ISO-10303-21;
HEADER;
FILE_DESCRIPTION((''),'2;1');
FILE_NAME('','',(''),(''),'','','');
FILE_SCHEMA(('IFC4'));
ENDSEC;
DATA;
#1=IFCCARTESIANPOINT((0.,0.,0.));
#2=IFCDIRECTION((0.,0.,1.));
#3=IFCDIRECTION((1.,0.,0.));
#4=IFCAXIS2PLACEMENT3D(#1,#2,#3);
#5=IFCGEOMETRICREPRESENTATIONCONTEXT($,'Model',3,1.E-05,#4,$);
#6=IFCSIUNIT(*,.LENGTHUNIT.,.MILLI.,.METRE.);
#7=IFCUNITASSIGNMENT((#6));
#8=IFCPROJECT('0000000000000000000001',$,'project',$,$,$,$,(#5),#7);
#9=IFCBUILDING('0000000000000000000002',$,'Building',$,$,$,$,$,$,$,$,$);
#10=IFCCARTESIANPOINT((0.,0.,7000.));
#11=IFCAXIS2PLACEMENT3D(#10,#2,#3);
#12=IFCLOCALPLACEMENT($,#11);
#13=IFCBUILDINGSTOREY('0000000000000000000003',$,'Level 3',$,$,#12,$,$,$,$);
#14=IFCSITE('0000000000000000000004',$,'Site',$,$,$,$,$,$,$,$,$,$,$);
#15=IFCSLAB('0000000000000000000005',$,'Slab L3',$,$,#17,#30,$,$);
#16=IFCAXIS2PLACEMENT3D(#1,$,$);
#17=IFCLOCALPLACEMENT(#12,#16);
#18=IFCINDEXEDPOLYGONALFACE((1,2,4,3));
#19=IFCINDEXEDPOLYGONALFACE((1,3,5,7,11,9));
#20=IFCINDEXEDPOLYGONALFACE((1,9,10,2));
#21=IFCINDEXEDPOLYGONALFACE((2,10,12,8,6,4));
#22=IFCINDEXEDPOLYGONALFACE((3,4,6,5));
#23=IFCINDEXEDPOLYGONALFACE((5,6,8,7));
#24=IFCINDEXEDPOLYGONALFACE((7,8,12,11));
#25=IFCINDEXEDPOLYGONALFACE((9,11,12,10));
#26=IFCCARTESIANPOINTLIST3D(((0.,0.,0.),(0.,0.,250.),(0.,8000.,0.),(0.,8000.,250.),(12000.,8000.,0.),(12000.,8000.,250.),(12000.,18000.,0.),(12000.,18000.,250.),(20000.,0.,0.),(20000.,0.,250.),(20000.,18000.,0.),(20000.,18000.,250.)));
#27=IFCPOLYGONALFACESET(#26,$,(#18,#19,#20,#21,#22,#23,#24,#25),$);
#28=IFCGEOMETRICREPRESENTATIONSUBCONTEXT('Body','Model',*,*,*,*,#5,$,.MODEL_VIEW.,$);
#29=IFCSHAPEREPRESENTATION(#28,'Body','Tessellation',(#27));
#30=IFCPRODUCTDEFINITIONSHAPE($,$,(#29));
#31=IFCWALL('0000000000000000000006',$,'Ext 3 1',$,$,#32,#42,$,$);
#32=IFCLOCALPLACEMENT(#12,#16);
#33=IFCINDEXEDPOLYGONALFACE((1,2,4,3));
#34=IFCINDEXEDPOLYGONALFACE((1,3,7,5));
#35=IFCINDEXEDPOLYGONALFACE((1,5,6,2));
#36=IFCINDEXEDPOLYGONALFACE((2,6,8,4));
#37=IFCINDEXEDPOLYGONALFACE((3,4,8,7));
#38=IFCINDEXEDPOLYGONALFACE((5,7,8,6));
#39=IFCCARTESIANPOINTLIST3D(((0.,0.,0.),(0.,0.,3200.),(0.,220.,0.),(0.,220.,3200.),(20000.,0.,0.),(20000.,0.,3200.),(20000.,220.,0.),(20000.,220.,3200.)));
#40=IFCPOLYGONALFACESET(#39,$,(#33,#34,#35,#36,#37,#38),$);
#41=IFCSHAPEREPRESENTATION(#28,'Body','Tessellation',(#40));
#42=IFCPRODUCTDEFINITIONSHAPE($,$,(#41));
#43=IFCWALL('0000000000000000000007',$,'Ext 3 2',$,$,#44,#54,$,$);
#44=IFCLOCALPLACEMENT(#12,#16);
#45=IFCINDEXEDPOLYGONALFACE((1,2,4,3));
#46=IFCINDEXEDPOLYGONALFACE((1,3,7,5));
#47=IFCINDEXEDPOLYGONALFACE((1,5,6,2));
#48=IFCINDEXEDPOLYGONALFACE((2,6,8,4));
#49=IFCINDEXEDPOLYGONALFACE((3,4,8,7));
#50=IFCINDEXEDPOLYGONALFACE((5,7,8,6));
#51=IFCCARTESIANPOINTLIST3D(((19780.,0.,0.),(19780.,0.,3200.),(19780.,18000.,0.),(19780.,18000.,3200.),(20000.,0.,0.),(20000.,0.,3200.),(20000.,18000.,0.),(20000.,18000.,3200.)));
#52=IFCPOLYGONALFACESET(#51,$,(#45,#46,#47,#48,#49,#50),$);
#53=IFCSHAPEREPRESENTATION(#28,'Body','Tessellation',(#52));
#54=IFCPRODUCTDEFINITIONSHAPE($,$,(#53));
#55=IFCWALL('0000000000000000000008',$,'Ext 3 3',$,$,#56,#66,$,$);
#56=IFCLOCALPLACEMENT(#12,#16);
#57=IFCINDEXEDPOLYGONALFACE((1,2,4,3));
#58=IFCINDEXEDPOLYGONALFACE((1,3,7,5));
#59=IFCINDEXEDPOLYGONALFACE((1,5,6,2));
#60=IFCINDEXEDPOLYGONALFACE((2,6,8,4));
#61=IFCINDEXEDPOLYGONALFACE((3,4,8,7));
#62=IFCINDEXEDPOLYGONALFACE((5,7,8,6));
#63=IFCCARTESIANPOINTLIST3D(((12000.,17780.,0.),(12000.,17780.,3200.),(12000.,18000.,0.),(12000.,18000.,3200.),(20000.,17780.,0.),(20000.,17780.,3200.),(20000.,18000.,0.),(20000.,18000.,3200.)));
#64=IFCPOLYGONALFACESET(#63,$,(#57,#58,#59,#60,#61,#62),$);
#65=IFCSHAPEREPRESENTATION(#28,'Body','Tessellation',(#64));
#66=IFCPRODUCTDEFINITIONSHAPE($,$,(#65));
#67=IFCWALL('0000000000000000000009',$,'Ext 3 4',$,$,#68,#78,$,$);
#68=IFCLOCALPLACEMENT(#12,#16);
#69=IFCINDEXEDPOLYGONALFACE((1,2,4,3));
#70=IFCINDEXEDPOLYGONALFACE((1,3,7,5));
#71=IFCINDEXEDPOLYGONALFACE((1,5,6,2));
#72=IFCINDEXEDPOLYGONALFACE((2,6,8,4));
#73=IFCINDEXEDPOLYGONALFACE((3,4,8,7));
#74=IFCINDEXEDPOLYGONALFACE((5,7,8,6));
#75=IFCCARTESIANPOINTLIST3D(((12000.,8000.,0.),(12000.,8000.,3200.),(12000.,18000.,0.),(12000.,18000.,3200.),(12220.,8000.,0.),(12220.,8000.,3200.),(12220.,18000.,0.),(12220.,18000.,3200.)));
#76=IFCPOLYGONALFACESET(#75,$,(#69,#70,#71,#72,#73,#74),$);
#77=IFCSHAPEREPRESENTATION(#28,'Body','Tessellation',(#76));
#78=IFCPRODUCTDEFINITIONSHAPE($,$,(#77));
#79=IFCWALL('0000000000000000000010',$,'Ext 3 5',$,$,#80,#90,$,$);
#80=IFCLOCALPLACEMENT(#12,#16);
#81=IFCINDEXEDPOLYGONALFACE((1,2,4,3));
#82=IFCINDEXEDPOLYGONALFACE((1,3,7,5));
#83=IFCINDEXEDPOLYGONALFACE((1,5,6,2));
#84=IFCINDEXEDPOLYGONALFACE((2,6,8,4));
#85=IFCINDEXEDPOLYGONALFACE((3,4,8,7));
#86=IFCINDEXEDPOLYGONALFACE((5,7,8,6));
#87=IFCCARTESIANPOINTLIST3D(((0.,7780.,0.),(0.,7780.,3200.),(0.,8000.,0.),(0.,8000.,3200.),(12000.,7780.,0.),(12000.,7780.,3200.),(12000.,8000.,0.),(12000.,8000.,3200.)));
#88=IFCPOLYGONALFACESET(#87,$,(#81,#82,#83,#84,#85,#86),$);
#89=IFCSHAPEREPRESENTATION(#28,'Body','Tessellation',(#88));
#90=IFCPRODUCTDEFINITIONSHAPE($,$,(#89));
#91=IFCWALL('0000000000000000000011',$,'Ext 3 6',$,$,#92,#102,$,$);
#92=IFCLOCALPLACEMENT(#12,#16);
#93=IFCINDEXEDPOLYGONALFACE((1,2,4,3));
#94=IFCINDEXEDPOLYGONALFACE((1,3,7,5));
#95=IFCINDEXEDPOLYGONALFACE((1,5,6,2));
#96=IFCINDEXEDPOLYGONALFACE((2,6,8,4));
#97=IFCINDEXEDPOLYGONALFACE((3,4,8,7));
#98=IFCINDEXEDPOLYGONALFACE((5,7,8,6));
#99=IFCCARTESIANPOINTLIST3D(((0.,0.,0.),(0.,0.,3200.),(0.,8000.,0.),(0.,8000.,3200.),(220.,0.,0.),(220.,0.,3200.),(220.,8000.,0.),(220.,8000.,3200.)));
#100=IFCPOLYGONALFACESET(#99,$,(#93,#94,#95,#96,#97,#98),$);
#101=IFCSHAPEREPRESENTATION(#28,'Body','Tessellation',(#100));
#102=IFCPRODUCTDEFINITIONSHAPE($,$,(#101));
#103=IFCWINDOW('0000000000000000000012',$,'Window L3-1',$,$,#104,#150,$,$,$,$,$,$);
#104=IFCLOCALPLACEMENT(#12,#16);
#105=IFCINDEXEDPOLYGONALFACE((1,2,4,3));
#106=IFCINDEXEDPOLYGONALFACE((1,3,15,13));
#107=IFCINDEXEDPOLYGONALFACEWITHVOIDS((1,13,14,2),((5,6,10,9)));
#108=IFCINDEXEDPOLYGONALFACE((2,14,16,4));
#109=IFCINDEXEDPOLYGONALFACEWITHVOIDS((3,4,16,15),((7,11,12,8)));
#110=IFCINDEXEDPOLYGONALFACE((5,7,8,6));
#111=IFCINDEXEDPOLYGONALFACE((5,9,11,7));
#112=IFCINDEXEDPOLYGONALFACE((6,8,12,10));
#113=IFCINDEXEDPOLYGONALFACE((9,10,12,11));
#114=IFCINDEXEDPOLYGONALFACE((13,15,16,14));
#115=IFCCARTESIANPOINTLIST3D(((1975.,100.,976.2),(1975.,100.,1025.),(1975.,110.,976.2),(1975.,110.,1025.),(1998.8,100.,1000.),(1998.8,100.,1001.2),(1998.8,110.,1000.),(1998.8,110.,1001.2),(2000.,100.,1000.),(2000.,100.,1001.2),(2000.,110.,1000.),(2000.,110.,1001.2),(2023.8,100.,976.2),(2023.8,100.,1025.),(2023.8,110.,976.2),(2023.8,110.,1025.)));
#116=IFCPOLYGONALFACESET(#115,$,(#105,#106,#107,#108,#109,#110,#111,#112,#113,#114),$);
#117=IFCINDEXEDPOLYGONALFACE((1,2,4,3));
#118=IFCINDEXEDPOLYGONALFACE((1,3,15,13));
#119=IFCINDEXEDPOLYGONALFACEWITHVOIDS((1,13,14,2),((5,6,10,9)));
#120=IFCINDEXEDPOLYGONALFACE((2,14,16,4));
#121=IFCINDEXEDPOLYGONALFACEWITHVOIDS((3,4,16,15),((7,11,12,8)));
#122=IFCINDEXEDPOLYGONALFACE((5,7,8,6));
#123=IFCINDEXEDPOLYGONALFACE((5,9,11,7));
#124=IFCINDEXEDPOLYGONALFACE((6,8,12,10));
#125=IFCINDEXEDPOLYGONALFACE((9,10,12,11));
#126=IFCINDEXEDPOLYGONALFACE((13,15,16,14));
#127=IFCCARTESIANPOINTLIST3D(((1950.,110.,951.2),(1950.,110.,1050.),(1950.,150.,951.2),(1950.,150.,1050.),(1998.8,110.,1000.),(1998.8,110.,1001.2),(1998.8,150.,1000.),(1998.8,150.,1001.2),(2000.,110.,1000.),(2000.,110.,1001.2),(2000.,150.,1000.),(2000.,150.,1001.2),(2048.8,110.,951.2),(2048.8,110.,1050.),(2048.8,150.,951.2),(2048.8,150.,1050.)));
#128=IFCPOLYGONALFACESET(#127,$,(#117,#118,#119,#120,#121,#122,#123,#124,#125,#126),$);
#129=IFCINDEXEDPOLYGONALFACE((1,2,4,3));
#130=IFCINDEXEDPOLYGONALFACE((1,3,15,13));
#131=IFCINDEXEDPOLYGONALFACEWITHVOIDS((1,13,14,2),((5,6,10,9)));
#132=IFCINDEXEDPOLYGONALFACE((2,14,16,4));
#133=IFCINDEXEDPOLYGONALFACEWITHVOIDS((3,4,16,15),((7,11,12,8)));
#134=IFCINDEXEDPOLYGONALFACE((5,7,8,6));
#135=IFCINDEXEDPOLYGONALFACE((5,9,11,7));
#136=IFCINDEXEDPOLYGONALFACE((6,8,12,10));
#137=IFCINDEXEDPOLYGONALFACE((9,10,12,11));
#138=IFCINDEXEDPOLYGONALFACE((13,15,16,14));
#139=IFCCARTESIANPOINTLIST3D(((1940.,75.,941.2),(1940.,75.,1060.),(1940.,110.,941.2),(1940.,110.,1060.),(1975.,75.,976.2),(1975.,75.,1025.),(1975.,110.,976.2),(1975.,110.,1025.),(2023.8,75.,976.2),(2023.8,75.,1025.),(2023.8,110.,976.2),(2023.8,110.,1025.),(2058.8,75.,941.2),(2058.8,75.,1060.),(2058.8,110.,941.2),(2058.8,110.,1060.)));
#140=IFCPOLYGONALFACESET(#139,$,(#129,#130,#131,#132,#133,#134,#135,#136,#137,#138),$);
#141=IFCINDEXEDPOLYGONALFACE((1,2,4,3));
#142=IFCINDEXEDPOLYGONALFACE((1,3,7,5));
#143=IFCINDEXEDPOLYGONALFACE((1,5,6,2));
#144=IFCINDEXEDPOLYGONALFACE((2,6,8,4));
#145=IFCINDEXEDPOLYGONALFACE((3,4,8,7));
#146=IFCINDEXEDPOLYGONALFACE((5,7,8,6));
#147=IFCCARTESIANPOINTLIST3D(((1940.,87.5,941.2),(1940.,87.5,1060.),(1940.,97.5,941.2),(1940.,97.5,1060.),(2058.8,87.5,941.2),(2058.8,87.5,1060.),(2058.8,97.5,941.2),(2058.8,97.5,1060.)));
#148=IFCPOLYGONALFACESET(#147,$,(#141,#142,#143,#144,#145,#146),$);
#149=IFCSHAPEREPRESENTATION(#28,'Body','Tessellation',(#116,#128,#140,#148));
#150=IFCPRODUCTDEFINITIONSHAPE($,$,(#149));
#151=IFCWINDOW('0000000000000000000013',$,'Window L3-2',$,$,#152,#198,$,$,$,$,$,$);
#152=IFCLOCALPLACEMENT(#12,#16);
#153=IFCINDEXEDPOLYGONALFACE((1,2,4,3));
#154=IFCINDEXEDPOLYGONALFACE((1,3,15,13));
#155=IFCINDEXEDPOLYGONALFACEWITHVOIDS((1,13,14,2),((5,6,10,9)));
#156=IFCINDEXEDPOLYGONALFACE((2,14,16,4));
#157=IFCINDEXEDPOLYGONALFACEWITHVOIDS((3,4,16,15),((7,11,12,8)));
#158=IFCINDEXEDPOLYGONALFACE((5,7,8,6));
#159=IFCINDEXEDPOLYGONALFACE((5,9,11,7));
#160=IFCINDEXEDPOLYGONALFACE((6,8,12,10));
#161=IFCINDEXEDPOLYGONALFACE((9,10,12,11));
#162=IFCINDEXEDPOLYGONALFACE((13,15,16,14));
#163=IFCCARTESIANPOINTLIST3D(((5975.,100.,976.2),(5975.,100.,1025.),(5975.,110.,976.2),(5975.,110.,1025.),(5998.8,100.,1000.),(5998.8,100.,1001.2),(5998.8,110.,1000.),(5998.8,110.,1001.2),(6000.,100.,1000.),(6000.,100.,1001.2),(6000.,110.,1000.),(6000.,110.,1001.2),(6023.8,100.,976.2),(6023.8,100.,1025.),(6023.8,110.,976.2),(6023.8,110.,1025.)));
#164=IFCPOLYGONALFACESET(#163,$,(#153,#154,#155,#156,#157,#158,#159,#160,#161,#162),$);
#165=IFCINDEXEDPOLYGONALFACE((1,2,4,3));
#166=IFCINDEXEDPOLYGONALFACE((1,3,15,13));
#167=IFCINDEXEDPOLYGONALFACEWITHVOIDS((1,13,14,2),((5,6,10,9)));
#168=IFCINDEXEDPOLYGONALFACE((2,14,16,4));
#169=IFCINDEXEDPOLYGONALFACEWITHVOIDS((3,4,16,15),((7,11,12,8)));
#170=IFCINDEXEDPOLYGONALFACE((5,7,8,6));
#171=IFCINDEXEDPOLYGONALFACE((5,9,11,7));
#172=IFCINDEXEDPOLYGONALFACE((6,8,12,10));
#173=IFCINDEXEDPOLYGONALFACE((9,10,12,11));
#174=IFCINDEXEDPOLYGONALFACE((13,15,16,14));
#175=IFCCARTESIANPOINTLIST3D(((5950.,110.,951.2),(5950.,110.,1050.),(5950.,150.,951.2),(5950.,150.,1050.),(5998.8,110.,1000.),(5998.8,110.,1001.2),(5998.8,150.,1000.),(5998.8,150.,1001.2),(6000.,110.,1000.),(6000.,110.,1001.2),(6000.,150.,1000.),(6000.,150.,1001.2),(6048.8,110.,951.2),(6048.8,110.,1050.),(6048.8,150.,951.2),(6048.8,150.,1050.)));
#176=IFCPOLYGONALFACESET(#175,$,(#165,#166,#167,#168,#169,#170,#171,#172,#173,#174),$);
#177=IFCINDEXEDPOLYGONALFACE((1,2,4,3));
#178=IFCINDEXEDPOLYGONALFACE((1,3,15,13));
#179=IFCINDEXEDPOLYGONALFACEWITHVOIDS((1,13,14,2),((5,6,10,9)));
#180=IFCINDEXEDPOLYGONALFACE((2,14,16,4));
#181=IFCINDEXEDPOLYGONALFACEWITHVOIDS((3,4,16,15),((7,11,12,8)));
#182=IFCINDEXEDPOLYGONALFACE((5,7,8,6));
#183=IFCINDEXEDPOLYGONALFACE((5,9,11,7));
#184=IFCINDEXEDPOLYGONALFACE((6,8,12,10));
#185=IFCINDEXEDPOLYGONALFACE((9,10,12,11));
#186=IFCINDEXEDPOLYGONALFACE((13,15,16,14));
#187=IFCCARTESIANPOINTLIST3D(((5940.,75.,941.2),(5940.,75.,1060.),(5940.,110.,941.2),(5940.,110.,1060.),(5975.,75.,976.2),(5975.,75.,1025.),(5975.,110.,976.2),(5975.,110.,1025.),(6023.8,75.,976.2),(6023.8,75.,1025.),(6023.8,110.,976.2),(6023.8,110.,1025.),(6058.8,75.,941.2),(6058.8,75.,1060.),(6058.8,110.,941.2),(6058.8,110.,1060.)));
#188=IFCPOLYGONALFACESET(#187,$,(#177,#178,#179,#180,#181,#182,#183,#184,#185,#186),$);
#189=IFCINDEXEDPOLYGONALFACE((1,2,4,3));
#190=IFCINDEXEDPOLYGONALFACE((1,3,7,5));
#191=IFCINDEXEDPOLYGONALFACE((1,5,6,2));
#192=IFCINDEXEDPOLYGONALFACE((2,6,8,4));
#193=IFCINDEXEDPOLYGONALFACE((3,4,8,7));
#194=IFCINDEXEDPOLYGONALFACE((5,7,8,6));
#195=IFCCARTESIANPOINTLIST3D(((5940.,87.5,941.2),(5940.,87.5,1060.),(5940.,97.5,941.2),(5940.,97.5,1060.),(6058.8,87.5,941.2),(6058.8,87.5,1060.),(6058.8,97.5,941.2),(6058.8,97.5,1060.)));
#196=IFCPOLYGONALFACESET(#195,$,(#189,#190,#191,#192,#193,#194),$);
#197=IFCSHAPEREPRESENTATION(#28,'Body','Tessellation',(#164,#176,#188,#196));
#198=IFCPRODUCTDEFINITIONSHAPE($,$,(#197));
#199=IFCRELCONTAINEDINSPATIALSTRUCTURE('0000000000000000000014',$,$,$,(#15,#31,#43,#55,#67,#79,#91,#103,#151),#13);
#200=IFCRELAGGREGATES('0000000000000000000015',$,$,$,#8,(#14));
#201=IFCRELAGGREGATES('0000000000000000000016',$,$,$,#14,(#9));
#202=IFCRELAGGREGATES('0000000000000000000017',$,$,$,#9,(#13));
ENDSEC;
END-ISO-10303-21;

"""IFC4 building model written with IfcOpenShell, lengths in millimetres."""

from ifc_helpers import new_model, si_unit, frame, origin_with_axes, place, context, subcontext, project, spatial, line, indexed_curve, outline, extrude, element, save


model = new_model("IFC4")

# Units and contexts
model_context = context("Model", 3, precision=1e-05, world=origin_with_axes())
body_context = subcontext(model_context, "Body", "Model", "MODEL_VIEW")
ifc_project = project(units=[si_unit("LENGTHUNIT", "METRE", prefix="MILLI")], contexts=[model_context])

# Site, building, storey
site = spatial("IfcSite", under=ifc_project, Name="Site")
building = spatial("IfcBuilding", under=site, Name="Building")
storey_placement = place(None, frame((0.0, 0.0, 7000.0), z_axis=(0.0, 0.0, 1.0), x_axis=(1.0, 0.0, 0.0)))
storey = spatial("IfcBuildingStorey", under=building, at=storey_placement, Name="Level 3")

# Slab
slab_placement = place(storey_placement, origin_with_axes())
element("IfcSlab", 1, at=slab_placement, inside=storey, Name="Slab L3", context=body_context, shape_type="SweptSolid", body=[
    extrude(outline(indexed_curve([(0.0, 0.0), (20000.0, 0.0), (20000.0, 18000.0), (12000.0, 18000.0), (12000.0, 8000.0), (0.0, 8000.0), (0.0, 0.0)])), None, (0.0, 0.0, 1.0), 250.0),
])

# Walls
wall_1_placement = place(storey_placement, origin_with_axes())
element("IfcWall", 2, at=wall_1_placement, inside=storey, Name="Ext 3 1", context=body_context, shape_type="SweptSolid", body=[
    extrude(outline(indexed_curve([(0.0, 0.0), (0.0, 220.0), (20000.0, 220.0), (20000.0, 0.0), (0.0, 0.0)], self_intersect=False)), origin_with_axes(), (0.0, 0.0, 1.0), 3200.0),
])
wall_2_placement = place(storey_placement, frame((20000.0, 0.0, 0.0), z_axis=(0.0, 0.0, 1.0), x_axis=(0.0, 1.0, 0.0)))
element("IfcWall", 3, at=wall_2_placement, inside=storey, Name="Ext 3 2", context=body_context, shape_type="SweptSolid", body=[
    extrude(outline(indexed_curve([(0.0, 0.0), (0.0, 220.0), (18000.0, 220.0), (18000.0, 0.0), (0.0, 0.0)], self_intersect=False)), origin_with_axes(), (0.0, 0.0, 1.0), 3200.0),
])
wall_3_placement = place(storey_placement, frame((20000.0, 18000.0, 0.0), z_axis=(0.0, 0.0, 1.0), x_axis=(-1.0, 0.0, 0.0)))
element("IfcWall", 4, at=wall_3_placement, inside=storey, Name="Ext 3 3", context=body_context, shape_type="SweptSolid", body=[
    extrude(outline(indexed_curve([(0.0, 0.0), (0.0, 220.0), (8000.0, 220.0), (8000.0, 0.0), (0.0, 0.0)], self_intersect=False)), origin_with_axes(), (0.0, 0.0, 1.0), 3200.0),
])
wall_4_placement = place(storey_placement, frame((12000.0, 18000.0, 0.0), z_axis=(0.0, 0.0, 1.0), x_axis=(0.0, -1.0, 0.0)))
element("IfcWall", 5, at=wall_4_placement, inside=storey, Name="Ext 3 4", context=body_context, shape_type="SweptSolid", body=[
    extrude(outline(indexed_curve([(0.0, 0.0), (0.0, 220.0), (10000.0, 220.0), (10000.0, 0.0), (0.0, 0.0)], self_intersect=False)), origin_with_axes(), (0.0, 0.0, 1.0), 3200.0),
])
wall_5_placement = place(storey_placement, frame((12000.0, 8000.0, 0.0), z_axis=(0.0, 0.0, 1.0), x_axis=(-1.0, 0.0, 0.0)))
element("IfcWall", 6, at=wall_5_placement, inside=storey, Name="Ext 3 5", context=body_context, shape_type="SweptSolid", body=[
    extrude(outline(indexed_curve([(0.0, 0.0), (0.0, 220.0), (12000.0, 220.0), (12000.0, 0.0), (0.0, 0.0)], self_intersect=False)), origin_with_axes(), (0.0, 0.0, 1.0), 3200.0),
])
wall_6_placement = place(storey_placement, frame((0.0, 8000.0, 0.0), z_axis=(0.0, 0.0, 1.0), x_axis=(0.0, -1.0, 0.0)))
element("IfcWall", 7, at=wall_6_placement, inside=storey, Name="Ext 3 6", context=body_context, shape_type="SweptSolid", body=[
    extrude(outline(indexed_curve([(0.0, 0.0), (0.0, 220.0), (8000.0, 220.0), (8000.0, 0.0), (0.0, 0.0)], self_intersect=False)), origin_with_axes(), (0.0, 0.0, 1.0), 3200.0),
])

# Windows
for number, where, z_axis, x_axis, name in (
    (8, (2000.0, 200.0, 1000.0), (0.0, 0.0, 1.0), (-1.0, 0.0, 0.0), "Window L3-1"),
    (9, (6000.0, 200.0, 1000.0), (0.0, 0.0, 1.0), (-1.0, 0.0, 0.0), "Window L3-2"),
):
    element("IfcWindow", number, at=place(storey_placement, frame(where, z_axis=z_axis, x_axis=x_axis)), inside=storey, Name=name, context=body_context, shape_type="SweptSolid", body=[
        extrude(outline(indexed_curve([(0.0, 0.0), (1.2, 0.0), (1.2, 1.2), (0.0, 1.2)], segments=[line(1, 2, 3, 4, 1)]), holes=[indexed_curve([(25.0, 25.0), (-23.8, 25.0), (-23.8, -23.8), (25.0, -23.8)], segments=[line(1, 2, 3, 4, 1)])]), frame((0.0, 90.0, 0.0), z_axis=(0.0, -1.0, 0.0), x_axis=(1.0, 0.0, 0.0)), (0.0, 0.0, -1.0), 10.0),
        extrude(outline(indexed_curve([(0.0, 0.0), (1.2, 0.0), (1.2, 1.2), (0.0, 1.2)], segments=[line(1, 2, 3, 4, 1)]), holes=[indexed_curve([(50.0, 50.0), (-48.8, 50.0), (-48.8, -48.8), (50.0, -48.8)], segments=[line(1, 2, 3, 4, 1)])]), frame((0.0, 50.0, 0.0), z_axis=(0.0, -1.0, 0.0), x_axis=(1.0, 0.0, 0.0)), (0.0, 0.0, -1.0), 40.0),
        extrude(outline(indexed_curve([(0.0, 0.0), (-48.8, 0.0), (-48.8, -48.8), (0.0, -48.8)], segments=[line(1, 2, 3, 4, 1)]), holes=[indexed_curve([(35.0, 35.0), (-83.8, 35.0), (-83.8, -83.8), (35.0, -83.8)], segments=[line(1, 2, 3, 4, 1)])]), frame((25.0, 90.0, 25.0), z_axis=(0.0, -1.0, 0.0), x_axis=(1.0, 0.0, 0.0)), (0.0, 0.0, -1.0), 35.0),
        extrude(outline(indexed_curve([(35.0, 35.0), (-83.8, 35.0), (-83.8, -83.8), (35.0, -83.8)], segments=[line(1, 2, 3, 4, 1)])), frame((25.0, 102.5, 25.0), z_axis=(0.0, -1.0, 0.0), x_axis=(1.0, 0.0, 0.0)), (0.0, 0.0, -1.0), 10.0),
    ])

save(model, "model.ifc")
